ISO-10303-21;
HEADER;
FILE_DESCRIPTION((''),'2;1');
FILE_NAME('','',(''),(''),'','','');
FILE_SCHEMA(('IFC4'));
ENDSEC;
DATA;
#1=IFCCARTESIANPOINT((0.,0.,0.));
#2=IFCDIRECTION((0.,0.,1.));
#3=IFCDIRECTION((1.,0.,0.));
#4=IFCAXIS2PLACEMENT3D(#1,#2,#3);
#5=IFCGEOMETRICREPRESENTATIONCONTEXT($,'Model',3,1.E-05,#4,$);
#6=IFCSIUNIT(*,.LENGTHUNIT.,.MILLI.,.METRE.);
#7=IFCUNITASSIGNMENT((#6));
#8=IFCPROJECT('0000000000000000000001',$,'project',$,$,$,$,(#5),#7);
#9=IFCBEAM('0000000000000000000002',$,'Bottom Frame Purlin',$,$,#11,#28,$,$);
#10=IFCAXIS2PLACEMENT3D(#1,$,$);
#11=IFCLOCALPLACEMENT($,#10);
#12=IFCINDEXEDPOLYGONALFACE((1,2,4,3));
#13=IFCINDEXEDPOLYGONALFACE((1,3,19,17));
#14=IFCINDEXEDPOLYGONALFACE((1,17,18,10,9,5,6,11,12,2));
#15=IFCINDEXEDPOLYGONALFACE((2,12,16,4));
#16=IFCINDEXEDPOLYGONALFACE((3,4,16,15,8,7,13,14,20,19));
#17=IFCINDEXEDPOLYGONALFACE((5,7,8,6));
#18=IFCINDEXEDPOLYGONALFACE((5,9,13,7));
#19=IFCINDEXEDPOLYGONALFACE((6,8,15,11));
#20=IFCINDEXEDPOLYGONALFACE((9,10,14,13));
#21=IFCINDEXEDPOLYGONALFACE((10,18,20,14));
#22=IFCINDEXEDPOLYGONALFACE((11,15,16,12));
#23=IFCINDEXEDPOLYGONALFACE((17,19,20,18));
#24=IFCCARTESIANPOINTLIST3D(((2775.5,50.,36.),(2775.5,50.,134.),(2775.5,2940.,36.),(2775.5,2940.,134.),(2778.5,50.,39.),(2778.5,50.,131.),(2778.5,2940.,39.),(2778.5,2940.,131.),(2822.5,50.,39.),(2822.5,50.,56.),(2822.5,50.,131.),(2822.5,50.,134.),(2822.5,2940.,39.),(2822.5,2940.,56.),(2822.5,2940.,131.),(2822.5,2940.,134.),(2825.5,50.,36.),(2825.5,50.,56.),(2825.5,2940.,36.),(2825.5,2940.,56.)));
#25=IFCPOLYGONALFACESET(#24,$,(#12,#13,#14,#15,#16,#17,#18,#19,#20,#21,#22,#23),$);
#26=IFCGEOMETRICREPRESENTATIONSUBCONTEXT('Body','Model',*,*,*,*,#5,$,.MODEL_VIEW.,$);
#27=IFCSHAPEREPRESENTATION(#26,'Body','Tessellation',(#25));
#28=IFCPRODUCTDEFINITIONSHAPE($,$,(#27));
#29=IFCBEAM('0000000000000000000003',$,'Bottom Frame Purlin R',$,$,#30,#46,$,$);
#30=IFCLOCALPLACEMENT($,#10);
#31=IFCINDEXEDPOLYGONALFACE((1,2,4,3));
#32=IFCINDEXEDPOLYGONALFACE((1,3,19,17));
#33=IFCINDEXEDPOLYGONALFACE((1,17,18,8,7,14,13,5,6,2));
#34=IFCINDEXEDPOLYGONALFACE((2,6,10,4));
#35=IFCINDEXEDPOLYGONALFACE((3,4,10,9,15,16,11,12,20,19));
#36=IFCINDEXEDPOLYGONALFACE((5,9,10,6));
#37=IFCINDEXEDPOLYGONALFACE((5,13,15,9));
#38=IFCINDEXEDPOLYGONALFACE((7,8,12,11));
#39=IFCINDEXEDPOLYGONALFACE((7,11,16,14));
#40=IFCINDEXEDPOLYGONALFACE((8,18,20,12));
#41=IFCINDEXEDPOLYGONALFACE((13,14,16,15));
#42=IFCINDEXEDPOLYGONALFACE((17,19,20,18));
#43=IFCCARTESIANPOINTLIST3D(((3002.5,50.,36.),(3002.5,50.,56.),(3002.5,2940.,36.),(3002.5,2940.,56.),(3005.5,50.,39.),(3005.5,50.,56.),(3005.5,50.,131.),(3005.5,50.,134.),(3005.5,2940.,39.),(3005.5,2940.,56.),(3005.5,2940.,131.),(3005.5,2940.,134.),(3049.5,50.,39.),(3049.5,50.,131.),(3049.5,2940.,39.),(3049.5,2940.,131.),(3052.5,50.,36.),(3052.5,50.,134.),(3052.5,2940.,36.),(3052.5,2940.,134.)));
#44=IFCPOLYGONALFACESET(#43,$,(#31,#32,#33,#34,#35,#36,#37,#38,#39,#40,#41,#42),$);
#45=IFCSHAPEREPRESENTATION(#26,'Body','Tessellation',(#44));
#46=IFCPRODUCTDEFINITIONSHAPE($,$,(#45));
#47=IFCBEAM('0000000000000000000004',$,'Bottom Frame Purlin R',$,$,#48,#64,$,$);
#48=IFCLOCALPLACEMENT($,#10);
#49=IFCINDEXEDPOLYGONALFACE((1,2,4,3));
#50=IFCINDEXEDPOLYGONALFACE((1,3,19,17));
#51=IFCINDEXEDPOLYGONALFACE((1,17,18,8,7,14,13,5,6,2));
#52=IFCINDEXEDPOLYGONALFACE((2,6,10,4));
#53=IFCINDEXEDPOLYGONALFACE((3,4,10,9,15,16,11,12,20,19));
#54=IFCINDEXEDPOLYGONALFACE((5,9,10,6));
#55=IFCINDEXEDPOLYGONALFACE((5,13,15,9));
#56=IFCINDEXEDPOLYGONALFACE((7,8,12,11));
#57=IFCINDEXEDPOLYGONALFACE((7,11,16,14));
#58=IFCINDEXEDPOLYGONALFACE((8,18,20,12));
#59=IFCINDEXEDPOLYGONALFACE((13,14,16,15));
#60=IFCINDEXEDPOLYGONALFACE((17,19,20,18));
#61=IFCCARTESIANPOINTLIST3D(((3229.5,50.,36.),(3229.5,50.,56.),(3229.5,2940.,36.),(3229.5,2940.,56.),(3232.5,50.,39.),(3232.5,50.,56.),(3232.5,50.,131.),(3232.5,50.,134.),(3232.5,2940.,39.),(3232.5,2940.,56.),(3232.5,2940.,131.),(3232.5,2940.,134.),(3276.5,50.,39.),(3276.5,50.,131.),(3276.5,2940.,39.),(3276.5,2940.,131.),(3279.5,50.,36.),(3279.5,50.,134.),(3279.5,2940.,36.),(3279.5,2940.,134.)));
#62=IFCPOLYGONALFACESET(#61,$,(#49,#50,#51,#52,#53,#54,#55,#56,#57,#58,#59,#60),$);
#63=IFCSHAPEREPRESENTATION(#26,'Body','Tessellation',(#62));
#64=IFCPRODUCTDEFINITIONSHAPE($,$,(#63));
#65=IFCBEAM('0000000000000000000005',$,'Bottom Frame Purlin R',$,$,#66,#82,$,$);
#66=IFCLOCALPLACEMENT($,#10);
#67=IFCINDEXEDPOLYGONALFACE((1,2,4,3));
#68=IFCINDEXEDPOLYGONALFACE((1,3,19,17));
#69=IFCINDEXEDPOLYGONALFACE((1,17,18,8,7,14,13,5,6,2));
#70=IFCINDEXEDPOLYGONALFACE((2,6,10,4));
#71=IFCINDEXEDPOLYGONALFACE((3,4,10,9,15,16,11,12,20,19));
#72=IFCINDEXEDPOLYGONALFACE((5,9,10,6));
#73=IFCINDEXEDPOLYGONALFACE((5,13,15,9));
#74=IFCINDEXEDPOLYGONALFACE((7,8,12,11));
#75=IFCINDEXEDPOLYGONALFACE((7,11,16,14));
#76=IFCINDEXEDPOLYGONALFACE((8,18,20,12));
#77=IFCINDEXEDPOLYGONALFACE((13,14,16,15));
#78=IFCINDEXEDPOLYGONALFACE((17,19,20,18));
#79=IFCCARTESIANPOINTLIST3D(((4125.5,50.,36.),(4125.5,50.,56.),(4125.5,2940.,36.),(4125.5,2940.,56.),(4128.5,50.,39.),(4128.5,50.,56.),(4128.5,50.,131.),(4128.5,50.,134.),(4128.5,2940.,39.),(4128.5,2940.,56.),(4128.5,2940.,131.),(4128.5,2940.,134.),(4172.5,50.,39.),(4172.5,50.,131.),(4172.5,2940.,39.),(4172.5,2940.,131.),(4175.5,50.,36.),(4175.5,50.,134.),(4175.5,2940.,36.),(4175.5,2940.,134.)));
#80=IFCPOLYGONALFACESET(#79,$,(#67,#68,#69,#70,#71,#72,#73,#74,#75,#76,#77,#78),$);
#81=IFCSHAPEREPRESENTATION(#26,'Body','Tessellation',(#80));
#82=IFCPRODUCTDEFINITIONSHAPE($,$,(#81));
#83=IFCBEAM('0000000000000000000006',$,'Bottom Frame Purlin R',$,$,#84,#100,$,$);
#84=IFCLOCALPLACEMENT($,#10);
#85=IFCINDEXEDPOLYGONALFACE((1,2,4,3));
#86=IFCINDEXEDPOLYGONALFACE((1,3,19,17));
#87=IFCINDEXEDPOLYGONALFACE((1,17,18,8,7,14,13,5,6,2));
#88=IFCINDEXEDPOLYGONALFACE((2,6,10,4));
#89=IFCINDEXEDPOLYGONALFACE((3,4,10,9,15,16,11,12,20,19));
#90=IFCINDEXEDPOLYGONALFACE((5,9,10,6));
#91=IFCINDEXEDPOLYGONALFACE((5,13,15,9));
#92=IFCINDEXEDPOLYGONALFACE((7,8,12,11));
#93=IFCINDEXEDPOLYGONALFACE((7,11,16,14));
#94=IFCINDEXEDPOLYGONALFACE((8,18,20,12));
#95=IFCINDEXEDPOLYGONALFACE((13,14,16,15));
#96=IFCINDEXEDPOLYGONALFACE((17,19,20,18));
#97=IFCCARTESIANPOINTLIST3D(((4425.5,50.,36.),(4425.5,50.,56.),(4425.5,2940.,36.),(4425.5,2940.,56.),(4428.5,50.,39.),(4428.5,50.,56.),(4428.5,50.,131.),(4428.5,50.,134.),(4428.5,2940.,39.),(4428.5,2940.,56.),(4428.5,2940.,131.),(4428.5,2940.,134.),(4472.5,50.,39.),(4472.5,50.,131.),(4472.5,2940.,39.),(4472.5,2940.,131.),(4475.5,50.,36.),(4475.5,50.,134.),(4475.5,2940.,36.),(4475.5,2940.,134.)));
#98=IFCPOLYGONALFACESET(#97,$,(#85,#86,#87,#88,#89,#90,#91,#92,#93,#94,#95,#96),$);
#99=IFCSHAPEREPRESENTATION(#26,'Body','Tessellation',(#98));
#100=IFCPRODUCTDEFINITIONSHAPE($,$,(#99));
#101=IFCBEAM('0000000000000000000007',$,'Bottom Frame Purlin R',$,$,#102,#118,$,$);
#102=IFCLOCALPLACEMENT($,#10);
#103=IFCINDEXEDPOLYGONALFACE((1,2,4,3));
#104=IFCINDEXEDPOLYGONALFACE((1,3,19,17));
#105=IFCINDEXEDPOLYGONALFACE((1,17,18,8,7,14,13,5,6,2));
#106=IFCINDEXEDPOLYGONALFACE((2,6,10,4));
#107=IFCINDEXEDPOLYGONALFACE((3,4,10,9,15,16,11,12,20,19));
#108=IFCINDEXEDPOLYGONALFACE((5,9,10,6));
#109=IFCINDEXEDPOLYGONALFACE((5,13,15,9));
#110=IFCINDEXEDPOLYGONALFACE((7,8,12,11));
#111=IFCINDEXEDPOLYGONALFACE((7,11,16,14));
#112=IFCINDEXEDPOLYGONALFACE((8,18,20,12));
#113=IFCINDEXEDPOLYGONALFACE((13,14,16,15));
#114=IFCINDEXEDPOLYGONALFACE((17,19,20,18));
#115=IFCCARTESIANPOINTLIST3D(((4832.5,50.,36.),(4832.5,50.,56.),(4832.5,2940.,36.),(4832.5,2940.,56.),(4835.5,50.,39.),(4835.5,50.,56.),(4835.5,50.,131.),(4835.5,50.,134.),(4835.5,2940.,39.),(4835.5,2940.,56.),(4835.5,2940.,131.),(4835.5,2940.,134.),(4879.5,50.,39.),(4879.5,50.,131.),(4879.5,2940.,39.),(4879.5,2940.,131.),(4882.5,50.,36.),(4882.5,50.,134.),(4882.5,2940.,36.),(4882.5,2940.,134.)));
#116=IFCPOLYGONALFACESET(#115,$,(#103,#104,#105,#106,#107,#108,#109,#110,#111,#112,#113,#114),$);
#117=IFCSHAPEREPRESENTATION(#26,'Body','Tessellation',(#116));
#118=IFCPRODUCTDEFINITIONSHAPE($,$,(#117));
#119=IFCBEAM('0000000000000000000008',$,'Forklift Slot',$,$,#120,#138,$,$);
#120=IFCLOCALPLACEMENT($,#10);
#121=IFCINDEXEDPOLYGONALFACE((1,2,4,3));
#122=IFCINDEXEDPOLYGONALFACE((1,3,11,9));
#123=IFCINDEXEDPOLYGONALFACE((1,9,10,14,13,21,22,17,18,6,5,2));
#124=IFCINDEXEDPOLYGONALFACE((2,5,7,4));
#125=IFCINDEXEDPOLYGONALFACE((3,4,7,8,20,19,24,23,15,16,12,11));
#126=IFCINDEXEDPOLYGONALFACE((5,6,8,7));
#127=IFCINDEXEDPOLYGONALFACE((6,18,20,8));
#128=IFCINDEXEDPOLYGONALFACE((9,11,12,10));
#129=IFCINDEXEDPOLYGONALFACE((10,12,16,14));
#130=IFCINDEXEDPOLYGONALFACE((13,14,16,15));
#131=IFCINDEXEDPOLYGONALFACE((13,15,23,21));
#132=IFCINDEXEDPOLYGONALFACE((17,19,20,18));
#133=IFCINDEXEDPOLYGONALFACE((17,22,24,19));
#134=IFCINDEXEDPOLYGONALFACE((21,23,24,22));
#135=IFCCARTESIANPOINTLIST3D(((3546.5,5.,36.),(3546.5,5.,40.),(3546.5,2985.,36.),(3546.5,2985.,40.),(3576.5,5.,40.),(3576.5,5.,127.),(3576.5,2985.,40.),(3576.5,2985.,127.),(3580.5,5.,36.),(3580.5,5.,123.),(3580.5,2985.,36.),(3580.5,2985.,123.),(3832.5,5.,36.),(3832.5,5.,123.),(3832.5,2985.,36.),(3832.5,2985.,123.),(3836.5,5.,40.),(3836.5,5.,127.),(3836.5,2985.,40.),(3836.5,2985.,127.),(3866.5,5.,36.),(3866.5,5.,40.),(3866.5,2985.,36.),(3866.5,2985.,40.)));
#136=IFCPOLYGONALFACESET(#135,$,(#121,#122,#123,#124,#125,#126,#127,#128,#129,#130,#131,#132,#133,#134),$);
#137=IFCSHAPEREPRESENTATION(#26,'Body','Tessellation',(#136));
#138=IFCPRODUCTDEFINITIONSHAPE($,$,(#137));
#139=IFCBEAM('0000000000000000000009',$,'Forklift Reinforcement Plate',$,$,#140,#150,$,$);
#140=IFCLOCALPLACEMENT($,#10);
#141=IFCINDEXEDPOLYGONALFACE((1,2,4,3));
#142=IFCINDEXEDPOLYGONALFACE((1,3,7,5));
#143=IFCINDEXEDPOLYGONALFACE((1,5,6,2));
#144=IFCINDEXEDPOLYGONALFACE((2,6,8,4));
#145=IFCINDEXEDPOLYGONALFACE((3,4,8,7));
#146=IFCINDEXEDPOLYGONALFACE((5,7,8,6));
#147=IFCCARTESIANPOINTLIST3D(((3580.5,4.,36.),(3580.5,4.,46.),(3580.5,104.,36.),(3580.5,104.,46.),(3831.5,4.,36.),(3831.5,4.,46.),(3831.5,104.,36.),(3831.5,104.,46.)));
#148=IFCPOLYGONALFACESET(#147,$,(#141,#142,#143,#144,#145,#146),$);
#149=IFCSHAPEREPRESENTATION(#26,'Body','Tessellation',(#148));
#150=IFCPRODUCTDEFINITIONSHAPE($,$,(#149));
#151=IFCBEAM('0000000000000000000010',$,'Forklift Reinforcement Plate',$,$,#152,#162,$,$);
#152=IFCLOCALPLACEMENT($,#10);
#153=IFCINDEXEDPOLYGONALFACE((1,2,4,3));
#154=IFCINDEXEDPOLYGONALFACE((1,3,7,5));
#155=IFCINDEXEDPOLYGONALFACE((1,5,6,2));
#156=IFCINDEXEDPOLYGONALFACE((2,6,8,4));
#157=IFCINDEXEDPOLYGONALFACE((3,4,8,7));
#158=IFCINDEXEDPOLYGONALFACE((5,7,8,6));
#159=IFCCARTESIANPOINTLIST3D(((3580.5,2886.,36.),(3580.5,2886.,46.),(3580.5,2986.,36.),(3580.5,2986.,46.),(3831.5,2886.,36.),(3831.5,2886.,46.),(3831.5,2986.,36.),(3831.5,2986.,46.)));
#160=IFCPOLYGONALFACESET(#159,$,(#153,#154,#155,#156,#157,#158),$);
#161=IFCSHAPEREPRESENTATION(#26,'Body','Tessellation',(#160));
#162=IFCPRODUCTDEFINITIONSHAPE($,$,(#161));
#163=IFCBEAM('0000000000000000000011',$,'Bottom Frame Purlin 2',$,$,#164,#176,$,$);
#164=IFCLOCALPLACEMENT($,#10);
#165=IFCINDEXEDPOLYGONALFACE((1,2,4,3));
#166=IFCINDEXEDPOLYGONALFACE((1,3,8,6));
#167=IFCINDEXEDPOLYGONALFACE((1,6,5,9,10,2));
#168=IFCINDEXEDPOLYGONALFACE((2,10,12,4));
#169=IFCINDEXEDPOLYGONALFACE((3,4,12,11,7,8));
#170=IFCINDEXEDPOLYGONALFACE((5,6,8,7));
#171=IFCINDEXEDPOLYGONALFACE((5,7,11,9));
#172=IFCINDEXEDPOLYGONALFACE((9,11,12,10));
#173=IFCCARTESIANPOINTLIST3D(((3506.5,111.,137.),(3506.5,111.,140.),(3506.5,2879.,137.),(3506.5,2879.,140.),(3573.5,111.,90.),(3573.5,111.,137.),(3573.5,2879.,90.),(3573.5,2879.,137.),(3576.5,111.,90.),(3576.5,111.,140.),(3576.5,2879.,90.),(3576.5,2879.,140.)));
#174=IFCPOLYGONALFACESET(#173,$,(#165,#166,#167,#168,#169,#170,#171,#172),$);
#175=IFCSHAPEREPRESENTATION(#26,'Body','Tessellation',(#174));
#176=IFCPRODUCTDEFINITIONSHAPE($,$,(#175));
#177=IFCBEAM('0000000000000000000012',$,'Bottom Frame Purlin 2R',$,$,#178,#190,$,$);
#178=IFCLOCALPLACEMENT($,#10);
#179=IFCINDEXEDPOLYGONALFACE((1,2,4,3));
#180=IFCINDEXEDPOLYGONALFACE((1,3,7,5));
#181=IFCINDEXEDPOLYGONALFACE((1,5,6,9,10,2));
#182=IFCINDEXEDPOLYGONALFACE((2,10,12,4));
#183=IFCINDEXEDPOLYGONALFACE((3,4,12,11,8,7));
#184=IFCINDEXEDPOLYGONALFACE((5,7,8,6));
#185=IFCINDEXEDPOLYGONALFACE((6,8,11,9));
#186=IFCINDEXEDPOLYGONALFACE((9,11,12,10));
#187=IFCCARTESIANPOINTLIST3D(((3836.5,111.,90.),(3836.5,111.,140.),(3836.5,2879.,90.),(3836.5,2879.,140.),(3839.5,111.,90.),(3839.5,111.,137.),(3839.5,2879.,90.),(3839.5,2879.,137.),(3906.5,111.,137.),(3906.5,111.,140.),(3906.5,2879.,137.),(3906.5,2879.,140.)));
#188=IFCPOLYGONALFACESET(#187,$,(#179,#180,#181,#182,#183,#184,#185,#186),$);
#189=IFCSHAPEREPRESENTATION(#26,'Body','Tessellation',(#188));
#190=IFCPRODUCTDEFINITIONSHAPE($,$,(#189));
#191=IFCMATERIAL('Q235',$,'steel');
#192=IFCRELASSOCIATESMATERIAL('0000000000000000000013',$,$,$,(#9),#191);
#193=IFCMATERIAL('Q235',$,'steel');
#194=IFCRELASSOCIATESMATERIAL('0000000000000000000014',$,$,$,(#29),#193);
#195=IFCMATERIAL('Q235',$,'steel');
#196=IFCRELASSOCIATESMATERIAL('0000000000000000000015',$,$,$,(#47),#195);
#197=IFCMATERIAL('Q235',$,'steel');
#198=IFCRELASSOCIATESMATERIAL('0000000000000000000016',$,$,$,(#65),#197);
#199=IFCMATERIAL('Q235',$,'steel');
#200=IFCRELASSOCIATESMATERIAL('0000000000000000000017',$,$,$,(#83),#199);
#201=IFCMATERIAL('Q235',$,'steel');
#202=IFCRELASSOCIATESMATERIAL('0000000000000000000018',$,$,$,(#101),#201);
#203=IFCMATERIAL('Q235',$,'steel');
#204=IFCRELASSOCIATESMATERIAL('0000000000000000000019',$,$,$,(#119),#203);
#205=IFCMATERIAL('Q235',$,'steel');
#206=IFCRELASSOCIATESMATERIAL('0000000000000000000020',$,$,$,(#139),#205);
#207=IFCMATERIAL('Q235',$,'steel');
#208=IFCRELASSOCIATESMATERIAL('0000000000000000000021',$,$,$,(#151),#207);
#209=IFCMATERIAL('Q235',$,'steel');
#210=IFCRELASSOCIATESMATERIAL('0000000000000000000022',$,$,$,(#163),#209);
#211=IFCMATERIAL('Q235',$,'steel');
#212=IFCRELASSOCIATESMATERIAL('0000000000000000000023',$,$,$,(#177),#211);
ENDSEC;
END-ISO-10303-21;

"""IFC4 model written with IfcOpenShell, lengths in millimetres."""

from ifc_helpers import new_model, si_unit, frame, origin_with_axes, place, context, subcontext, project, line, indexed_curve, outline, extrude, material, element, save


model = new_model("IFC4")

# Units and contexts
model_context = context("Model", 3, precision=1e-05, world=origin_with_axes())
body_context = subcontext(model_context, "Body", "Model", "MODEL_VIEW")
ifc_project = project(units=[si_unit("LENGTHUNIT", "METRE", prefix="MILLI")], contexts=[model_context])

# Beams
ifc_material_1 = material(Name="Q235", Category="steel")
beam_1_placement = place(None, frame((2775.5, 50.0, 36.0), z_axis=(0.0, 1.0, 0.0), x_axis=(1.0, 0.0, 0.0)))
element("IfcBeam", 1, at=beam_1_placement, material=ifc_material_1, Name="Bottom Frame Purlin", context=body_context, shape_type="SweptSolid", body=[
    extrude(outline(indexed_curve([(0.0, 0.0), (50.0, 0.0), (50.0, -20.0), (47.0, -20.0), (47.0, -3.0), (3.0, -3.0), (3.0, -95.0), (47.0, -95.0), (47.0, -138.0), (50.0, -78.0), (50.0, -98.0), (0.0, -98.0), (0.0, 0.0)], segments=[line(1, 2, 3, 4, 5, 6, 7, 8, 9, 10, 11, 12, 13, 1)])), origin_with_axes(), (0.0, 0.0, 1.0), 2890.0),
])
ifc_material_2 = material(Name="Q235", Category="steel")
beam_2_placement = place(None, frame((3052.5, 50.0, 36.0), z_axis=(0.0, 1.0, 0.0), x_axis=(-1.0, 0.0, 0.0)))
element("IfcBeam", 2, at=beam_2_placement, material=ifc_material_2, Name="Bottom Frame Purlin R", context=body_context, shape_type="SweptSolid", body=[
    extrude(outline(indexed_curve([(0.0, 0.0), (50.0, 0.0), (50.0, 20.0), (47.0, 20.0), (47.0, 3.0), (3.0, 3.0), (3.0, 95.0), (47.0, 95.0), (47.0, 138.0), (50.0, 78.0), (50.0, 98.0), (0.0, 98.0), (0.0, 0.0)], segments=[line(1, 2, 3, 4, 5, 6, 7, 8, 9, 10, 11, 12, 13, 1)])), origin_with_axes(), (0.0, 0.0, 1.0), 2890.0),
])
ifc_material_3 = material(Name="Q235", Category="steel")
beam_3_placement = place(None, frame((3279.5, 50.0, 36.0), z_axis=(0.0, 1.0, 0.0), x_axis=(-1.0, 0.0, 0.0)))
element("IfcBeam", 3, at=beam_3_placement, material=ifc_material_3, Name="Bottom Frame Purlin R", context=body_context, shape_type="SweptSolid", body=[
    extrude(outline(indexed_curve([(0.0, 0.0), (50.0, 0.0), (50.0, 20.0), (47.0, 20.0), (47.0, 3.0), (3.0, 3.0), (3.0, 95.0), (47.0, 95.0), (47.0, 138.0), (50.0, 78.0), (50.0, 98.0), (0.0, 98.0), (0.0, 0.0)], segments=[line(1, 2, 3, 4, 5, 6, 7, 8, 9, 10, 11, 12, 13, 1)])), origin_with_axes(), (0.0, 0.0, 1.0), 2890.0),
])
ifc_material_4 = material(Name="Q235", Category="steel")
beam_4_placement = place(None, frame((4175.5, 50.0, 36.0), z_axis=(0.0, 1.0, 0.0), x_axis=(-1.0, 0.0, 0.0)))
element("IfcBeam", 4, at=beam_4_placement, material=ifc_material_4, Name="Bottom Frame Purlin R", context=body_context, shape_type="SweptSolid", body=[
    extrude(outline(indexed_curve([(0.0, 0.0), (50.0, 0.0), (50.0, 20.0), (47.0, 20.0), (47.0, 3.0), (3.0, 3.0), (3.0, 95.0), (47.0, 95.0), (47.0, 138.0), (50.0, 78.0), (50.0, 98.0), (0.0, 98.0), (0.0, 0.0)], segments=[line(1, 2, 3, 4, 5, 6, 7, 8, 9, 10, 11, 12, 13, 1)])), origin_with_axes(), (0.0, 0.0, 1.0), 2890.0),
])
ifc_material_5 = material(Name="Q235", Category="steel")
beam_5_placement = place(None, frame((4475.5, 50.0, 36.0), z_axis=(0.0, 1.0, 0.0), x_axis=(-1.0, 0.0, 0.0)))
element("IfcBeam", 5, at=beam_5_placement, material=ifc_material_5, Name="Bottom Frame Purlin R", context=body_context, shape_type="SweptSolid", body=[
    extrude(outline(indexed_curve([(0.0, 0.0), (50.0, 0.0), (50.0, 20.0), (47.0, 20.0), (47.0, 3.0), (3.0, 3.0), (3.0, 95.0), (47.0, 95.0), (47.0, 138.0), (50.0, 78.0), (50.0, 98.0), (0.0, 98.0), (0.0, 0.0)], segments=[line(1, 2, 3, 4, 5, 6, 7, 8, 9, 10, 11, 12, 13, 1)])), origin_with_axes(), (0.0, 0.0, 1.0), 2890.0),
])
ifc_material_6 = material(Name="Q235", Category="steel")
beam_6_placement = place(None, frame((4882.5, 50.0, 36.0), z_axis=(0.0, 1.0, 0.0), x_axis=(-1.0, 0.0, 0.0)))
element("IfcBeam", 6, at=beam_6_placement, material=ifc_material_6, Name="Bottom Frame Purlin R", context=body_context, shape_type="SweptSolid", body=[
    extrude(outline(indexed_curve([(0.0, 0.0), (50.0, 0.0), (50.0, 20.0), (47.0, 20.0), (47.0, 3.0), (3.0, 3.0), (3.0, 95.0), (47.0, 95.0), (47.0, 138.0), (50.0, 78.0), (50.0, 98.0), (0.0, 98.0), (0.0, 0.0)], segments=[line(1, 2, 3, 4, 5, 6, 7, 8, 9, 10, 11, 12, 13, 1)])), origin_with_axes(), (0.0, 0.0, 1.0), 2890.0),
])
ifc_material_7 = material(Name="Q235", Category="steel")
beam_7_placement = place(None, frame((3576.5, 5.0, 127.0), z_axis=(0.0, 1.0, 0.0), x_axis=(1.0, 0.0, 0.0)))
element("IfcBeam", 7, at=beam_7_placement, material=ifc_material_7, Name="Forklift Slot", context=body_context, shape_type="SweptSolid", body=[
    extrude(outline(indexed_curve([(0.0, 0.0), (260.0, 0.0), (260.0, 87.0), (290.0, 87.0), (290.0, 91.0), (256.0, 91.0), (256.0, 4.0), (4.0, 4.0), (4.0, 91.0), (-30.0, 91.0), (-30.0, 87.0), (0.0, 87.0), (0.0, 0.0)], segments=[line(1, 2, 3, 4, 5, 6, 7, 8, 9, 10, 11, 12, 13, 1)])), origin_with_axes(), (0.0, 0.0, 1.0), 2980.0),
])
ifc_material_8 = material(Name="Q235", Category="steel")
beam_8_placement = place(None, frame((3580.5, 4.0, 36.0), z_axis=(0.0, 0.0, 1.0), x_axis=(1.0, 0.0, 0.0)))
element("IfcBeam", 8, at=beam_8_placement, material=ifc_material_8, Name="Forklift Reinforcement Plate", context=body_context, shape_type="SweptSolid", body=[
    extrude(outline(indexed_curve([(0.0, 0.0), (0.0, 100.0), (251.0, 100.0), (251.0, 0.0), (0.0, 0.0)], segments=[line(1, 2, 3, 4, 5, 1)])), origin_with_axes(), (0.0, 0.0, 1.0), 10.0),
])
ifc_material_9 = material(Name="Q235", Category="steel")
beam_9_placement = place(None, frame((3580.5, 2886.0, 36.0), z_axis=(0.0, 0.0, 1.0), x_axis=(1.0, 0.0, 0.0)))
element("IfcBeam", 9, at=beam_9_placement, material=ifc_material_9, Name="Forklift Reinforcement Plate", context=body_context, shape_type="SweptSolid", body=[
    extrude(outline(indexed_curve([(0.0, 0.0), (0.0, 100.0), (251.0, 100.0), (251.0, 0.0), (0.0, 0.0)], segments=[line(1, 2, 3, 4, 5, 1)])), origin_with_axes(), (0.0, 0.0, 1.0), 10.0),
])
ifc_material_10 = material(Name="Q235", Category="steel")
beam_10_placement = place(None, frame((3576.5, 111.0, 140.0), z_axis=(0.0, 1.0, 0.0), x_axis=(-1.0, 0.0, 0.0)))
element("IfcBeam", 10, at=beam_10_placement, material=ifc_material_10, Name="Bottom Frame Purlin 2", context=body_context, shape_type="SweptSolid", body=[
    extrude(outline(indexed_curve([(0.0, 0.0), (0.0, -50.0), (3.0, -50.0), (3.0, -3.0), (70.0, -3.0), (70.0, 0.0), (0.0, 0.0)], segments=[line(1, 2, 3, 4, 5, 6, 7, 1)])), origin_with_axes(), (0.0, 0.0, 1.0), 2768.0),
])
ifc_material_11 = material(Name="Q235", Category="steel")
beam_11_placement = place(None, frame((3836.5, 111.0, 140.0), z_axis=(0.0, 1.0, 0.0), x_axis=(1.0, 0.0, 0.0)))
element("IfcBeam", 11, at=beam_11_placement, material=ifc_material_11, Name="Bottom Frame Purlin 2R", context=body_context, shape_type="SweptSolid", body=[
    extrude(outline(indexed_curve([(0.0, 0.0), (0.0, 50.0), (3.0, 50.0), (3.0, 3.0), (70.0, 3.0), (70.0, 0.0), (0.0, 0.0)], segments=[line(1, 2, 3, 4, 5, 6, 7, 1)])), origin_with_axes(), (0.0, 0.0, 1.0), 2768.0),
])

save(model, "model.ifc")
